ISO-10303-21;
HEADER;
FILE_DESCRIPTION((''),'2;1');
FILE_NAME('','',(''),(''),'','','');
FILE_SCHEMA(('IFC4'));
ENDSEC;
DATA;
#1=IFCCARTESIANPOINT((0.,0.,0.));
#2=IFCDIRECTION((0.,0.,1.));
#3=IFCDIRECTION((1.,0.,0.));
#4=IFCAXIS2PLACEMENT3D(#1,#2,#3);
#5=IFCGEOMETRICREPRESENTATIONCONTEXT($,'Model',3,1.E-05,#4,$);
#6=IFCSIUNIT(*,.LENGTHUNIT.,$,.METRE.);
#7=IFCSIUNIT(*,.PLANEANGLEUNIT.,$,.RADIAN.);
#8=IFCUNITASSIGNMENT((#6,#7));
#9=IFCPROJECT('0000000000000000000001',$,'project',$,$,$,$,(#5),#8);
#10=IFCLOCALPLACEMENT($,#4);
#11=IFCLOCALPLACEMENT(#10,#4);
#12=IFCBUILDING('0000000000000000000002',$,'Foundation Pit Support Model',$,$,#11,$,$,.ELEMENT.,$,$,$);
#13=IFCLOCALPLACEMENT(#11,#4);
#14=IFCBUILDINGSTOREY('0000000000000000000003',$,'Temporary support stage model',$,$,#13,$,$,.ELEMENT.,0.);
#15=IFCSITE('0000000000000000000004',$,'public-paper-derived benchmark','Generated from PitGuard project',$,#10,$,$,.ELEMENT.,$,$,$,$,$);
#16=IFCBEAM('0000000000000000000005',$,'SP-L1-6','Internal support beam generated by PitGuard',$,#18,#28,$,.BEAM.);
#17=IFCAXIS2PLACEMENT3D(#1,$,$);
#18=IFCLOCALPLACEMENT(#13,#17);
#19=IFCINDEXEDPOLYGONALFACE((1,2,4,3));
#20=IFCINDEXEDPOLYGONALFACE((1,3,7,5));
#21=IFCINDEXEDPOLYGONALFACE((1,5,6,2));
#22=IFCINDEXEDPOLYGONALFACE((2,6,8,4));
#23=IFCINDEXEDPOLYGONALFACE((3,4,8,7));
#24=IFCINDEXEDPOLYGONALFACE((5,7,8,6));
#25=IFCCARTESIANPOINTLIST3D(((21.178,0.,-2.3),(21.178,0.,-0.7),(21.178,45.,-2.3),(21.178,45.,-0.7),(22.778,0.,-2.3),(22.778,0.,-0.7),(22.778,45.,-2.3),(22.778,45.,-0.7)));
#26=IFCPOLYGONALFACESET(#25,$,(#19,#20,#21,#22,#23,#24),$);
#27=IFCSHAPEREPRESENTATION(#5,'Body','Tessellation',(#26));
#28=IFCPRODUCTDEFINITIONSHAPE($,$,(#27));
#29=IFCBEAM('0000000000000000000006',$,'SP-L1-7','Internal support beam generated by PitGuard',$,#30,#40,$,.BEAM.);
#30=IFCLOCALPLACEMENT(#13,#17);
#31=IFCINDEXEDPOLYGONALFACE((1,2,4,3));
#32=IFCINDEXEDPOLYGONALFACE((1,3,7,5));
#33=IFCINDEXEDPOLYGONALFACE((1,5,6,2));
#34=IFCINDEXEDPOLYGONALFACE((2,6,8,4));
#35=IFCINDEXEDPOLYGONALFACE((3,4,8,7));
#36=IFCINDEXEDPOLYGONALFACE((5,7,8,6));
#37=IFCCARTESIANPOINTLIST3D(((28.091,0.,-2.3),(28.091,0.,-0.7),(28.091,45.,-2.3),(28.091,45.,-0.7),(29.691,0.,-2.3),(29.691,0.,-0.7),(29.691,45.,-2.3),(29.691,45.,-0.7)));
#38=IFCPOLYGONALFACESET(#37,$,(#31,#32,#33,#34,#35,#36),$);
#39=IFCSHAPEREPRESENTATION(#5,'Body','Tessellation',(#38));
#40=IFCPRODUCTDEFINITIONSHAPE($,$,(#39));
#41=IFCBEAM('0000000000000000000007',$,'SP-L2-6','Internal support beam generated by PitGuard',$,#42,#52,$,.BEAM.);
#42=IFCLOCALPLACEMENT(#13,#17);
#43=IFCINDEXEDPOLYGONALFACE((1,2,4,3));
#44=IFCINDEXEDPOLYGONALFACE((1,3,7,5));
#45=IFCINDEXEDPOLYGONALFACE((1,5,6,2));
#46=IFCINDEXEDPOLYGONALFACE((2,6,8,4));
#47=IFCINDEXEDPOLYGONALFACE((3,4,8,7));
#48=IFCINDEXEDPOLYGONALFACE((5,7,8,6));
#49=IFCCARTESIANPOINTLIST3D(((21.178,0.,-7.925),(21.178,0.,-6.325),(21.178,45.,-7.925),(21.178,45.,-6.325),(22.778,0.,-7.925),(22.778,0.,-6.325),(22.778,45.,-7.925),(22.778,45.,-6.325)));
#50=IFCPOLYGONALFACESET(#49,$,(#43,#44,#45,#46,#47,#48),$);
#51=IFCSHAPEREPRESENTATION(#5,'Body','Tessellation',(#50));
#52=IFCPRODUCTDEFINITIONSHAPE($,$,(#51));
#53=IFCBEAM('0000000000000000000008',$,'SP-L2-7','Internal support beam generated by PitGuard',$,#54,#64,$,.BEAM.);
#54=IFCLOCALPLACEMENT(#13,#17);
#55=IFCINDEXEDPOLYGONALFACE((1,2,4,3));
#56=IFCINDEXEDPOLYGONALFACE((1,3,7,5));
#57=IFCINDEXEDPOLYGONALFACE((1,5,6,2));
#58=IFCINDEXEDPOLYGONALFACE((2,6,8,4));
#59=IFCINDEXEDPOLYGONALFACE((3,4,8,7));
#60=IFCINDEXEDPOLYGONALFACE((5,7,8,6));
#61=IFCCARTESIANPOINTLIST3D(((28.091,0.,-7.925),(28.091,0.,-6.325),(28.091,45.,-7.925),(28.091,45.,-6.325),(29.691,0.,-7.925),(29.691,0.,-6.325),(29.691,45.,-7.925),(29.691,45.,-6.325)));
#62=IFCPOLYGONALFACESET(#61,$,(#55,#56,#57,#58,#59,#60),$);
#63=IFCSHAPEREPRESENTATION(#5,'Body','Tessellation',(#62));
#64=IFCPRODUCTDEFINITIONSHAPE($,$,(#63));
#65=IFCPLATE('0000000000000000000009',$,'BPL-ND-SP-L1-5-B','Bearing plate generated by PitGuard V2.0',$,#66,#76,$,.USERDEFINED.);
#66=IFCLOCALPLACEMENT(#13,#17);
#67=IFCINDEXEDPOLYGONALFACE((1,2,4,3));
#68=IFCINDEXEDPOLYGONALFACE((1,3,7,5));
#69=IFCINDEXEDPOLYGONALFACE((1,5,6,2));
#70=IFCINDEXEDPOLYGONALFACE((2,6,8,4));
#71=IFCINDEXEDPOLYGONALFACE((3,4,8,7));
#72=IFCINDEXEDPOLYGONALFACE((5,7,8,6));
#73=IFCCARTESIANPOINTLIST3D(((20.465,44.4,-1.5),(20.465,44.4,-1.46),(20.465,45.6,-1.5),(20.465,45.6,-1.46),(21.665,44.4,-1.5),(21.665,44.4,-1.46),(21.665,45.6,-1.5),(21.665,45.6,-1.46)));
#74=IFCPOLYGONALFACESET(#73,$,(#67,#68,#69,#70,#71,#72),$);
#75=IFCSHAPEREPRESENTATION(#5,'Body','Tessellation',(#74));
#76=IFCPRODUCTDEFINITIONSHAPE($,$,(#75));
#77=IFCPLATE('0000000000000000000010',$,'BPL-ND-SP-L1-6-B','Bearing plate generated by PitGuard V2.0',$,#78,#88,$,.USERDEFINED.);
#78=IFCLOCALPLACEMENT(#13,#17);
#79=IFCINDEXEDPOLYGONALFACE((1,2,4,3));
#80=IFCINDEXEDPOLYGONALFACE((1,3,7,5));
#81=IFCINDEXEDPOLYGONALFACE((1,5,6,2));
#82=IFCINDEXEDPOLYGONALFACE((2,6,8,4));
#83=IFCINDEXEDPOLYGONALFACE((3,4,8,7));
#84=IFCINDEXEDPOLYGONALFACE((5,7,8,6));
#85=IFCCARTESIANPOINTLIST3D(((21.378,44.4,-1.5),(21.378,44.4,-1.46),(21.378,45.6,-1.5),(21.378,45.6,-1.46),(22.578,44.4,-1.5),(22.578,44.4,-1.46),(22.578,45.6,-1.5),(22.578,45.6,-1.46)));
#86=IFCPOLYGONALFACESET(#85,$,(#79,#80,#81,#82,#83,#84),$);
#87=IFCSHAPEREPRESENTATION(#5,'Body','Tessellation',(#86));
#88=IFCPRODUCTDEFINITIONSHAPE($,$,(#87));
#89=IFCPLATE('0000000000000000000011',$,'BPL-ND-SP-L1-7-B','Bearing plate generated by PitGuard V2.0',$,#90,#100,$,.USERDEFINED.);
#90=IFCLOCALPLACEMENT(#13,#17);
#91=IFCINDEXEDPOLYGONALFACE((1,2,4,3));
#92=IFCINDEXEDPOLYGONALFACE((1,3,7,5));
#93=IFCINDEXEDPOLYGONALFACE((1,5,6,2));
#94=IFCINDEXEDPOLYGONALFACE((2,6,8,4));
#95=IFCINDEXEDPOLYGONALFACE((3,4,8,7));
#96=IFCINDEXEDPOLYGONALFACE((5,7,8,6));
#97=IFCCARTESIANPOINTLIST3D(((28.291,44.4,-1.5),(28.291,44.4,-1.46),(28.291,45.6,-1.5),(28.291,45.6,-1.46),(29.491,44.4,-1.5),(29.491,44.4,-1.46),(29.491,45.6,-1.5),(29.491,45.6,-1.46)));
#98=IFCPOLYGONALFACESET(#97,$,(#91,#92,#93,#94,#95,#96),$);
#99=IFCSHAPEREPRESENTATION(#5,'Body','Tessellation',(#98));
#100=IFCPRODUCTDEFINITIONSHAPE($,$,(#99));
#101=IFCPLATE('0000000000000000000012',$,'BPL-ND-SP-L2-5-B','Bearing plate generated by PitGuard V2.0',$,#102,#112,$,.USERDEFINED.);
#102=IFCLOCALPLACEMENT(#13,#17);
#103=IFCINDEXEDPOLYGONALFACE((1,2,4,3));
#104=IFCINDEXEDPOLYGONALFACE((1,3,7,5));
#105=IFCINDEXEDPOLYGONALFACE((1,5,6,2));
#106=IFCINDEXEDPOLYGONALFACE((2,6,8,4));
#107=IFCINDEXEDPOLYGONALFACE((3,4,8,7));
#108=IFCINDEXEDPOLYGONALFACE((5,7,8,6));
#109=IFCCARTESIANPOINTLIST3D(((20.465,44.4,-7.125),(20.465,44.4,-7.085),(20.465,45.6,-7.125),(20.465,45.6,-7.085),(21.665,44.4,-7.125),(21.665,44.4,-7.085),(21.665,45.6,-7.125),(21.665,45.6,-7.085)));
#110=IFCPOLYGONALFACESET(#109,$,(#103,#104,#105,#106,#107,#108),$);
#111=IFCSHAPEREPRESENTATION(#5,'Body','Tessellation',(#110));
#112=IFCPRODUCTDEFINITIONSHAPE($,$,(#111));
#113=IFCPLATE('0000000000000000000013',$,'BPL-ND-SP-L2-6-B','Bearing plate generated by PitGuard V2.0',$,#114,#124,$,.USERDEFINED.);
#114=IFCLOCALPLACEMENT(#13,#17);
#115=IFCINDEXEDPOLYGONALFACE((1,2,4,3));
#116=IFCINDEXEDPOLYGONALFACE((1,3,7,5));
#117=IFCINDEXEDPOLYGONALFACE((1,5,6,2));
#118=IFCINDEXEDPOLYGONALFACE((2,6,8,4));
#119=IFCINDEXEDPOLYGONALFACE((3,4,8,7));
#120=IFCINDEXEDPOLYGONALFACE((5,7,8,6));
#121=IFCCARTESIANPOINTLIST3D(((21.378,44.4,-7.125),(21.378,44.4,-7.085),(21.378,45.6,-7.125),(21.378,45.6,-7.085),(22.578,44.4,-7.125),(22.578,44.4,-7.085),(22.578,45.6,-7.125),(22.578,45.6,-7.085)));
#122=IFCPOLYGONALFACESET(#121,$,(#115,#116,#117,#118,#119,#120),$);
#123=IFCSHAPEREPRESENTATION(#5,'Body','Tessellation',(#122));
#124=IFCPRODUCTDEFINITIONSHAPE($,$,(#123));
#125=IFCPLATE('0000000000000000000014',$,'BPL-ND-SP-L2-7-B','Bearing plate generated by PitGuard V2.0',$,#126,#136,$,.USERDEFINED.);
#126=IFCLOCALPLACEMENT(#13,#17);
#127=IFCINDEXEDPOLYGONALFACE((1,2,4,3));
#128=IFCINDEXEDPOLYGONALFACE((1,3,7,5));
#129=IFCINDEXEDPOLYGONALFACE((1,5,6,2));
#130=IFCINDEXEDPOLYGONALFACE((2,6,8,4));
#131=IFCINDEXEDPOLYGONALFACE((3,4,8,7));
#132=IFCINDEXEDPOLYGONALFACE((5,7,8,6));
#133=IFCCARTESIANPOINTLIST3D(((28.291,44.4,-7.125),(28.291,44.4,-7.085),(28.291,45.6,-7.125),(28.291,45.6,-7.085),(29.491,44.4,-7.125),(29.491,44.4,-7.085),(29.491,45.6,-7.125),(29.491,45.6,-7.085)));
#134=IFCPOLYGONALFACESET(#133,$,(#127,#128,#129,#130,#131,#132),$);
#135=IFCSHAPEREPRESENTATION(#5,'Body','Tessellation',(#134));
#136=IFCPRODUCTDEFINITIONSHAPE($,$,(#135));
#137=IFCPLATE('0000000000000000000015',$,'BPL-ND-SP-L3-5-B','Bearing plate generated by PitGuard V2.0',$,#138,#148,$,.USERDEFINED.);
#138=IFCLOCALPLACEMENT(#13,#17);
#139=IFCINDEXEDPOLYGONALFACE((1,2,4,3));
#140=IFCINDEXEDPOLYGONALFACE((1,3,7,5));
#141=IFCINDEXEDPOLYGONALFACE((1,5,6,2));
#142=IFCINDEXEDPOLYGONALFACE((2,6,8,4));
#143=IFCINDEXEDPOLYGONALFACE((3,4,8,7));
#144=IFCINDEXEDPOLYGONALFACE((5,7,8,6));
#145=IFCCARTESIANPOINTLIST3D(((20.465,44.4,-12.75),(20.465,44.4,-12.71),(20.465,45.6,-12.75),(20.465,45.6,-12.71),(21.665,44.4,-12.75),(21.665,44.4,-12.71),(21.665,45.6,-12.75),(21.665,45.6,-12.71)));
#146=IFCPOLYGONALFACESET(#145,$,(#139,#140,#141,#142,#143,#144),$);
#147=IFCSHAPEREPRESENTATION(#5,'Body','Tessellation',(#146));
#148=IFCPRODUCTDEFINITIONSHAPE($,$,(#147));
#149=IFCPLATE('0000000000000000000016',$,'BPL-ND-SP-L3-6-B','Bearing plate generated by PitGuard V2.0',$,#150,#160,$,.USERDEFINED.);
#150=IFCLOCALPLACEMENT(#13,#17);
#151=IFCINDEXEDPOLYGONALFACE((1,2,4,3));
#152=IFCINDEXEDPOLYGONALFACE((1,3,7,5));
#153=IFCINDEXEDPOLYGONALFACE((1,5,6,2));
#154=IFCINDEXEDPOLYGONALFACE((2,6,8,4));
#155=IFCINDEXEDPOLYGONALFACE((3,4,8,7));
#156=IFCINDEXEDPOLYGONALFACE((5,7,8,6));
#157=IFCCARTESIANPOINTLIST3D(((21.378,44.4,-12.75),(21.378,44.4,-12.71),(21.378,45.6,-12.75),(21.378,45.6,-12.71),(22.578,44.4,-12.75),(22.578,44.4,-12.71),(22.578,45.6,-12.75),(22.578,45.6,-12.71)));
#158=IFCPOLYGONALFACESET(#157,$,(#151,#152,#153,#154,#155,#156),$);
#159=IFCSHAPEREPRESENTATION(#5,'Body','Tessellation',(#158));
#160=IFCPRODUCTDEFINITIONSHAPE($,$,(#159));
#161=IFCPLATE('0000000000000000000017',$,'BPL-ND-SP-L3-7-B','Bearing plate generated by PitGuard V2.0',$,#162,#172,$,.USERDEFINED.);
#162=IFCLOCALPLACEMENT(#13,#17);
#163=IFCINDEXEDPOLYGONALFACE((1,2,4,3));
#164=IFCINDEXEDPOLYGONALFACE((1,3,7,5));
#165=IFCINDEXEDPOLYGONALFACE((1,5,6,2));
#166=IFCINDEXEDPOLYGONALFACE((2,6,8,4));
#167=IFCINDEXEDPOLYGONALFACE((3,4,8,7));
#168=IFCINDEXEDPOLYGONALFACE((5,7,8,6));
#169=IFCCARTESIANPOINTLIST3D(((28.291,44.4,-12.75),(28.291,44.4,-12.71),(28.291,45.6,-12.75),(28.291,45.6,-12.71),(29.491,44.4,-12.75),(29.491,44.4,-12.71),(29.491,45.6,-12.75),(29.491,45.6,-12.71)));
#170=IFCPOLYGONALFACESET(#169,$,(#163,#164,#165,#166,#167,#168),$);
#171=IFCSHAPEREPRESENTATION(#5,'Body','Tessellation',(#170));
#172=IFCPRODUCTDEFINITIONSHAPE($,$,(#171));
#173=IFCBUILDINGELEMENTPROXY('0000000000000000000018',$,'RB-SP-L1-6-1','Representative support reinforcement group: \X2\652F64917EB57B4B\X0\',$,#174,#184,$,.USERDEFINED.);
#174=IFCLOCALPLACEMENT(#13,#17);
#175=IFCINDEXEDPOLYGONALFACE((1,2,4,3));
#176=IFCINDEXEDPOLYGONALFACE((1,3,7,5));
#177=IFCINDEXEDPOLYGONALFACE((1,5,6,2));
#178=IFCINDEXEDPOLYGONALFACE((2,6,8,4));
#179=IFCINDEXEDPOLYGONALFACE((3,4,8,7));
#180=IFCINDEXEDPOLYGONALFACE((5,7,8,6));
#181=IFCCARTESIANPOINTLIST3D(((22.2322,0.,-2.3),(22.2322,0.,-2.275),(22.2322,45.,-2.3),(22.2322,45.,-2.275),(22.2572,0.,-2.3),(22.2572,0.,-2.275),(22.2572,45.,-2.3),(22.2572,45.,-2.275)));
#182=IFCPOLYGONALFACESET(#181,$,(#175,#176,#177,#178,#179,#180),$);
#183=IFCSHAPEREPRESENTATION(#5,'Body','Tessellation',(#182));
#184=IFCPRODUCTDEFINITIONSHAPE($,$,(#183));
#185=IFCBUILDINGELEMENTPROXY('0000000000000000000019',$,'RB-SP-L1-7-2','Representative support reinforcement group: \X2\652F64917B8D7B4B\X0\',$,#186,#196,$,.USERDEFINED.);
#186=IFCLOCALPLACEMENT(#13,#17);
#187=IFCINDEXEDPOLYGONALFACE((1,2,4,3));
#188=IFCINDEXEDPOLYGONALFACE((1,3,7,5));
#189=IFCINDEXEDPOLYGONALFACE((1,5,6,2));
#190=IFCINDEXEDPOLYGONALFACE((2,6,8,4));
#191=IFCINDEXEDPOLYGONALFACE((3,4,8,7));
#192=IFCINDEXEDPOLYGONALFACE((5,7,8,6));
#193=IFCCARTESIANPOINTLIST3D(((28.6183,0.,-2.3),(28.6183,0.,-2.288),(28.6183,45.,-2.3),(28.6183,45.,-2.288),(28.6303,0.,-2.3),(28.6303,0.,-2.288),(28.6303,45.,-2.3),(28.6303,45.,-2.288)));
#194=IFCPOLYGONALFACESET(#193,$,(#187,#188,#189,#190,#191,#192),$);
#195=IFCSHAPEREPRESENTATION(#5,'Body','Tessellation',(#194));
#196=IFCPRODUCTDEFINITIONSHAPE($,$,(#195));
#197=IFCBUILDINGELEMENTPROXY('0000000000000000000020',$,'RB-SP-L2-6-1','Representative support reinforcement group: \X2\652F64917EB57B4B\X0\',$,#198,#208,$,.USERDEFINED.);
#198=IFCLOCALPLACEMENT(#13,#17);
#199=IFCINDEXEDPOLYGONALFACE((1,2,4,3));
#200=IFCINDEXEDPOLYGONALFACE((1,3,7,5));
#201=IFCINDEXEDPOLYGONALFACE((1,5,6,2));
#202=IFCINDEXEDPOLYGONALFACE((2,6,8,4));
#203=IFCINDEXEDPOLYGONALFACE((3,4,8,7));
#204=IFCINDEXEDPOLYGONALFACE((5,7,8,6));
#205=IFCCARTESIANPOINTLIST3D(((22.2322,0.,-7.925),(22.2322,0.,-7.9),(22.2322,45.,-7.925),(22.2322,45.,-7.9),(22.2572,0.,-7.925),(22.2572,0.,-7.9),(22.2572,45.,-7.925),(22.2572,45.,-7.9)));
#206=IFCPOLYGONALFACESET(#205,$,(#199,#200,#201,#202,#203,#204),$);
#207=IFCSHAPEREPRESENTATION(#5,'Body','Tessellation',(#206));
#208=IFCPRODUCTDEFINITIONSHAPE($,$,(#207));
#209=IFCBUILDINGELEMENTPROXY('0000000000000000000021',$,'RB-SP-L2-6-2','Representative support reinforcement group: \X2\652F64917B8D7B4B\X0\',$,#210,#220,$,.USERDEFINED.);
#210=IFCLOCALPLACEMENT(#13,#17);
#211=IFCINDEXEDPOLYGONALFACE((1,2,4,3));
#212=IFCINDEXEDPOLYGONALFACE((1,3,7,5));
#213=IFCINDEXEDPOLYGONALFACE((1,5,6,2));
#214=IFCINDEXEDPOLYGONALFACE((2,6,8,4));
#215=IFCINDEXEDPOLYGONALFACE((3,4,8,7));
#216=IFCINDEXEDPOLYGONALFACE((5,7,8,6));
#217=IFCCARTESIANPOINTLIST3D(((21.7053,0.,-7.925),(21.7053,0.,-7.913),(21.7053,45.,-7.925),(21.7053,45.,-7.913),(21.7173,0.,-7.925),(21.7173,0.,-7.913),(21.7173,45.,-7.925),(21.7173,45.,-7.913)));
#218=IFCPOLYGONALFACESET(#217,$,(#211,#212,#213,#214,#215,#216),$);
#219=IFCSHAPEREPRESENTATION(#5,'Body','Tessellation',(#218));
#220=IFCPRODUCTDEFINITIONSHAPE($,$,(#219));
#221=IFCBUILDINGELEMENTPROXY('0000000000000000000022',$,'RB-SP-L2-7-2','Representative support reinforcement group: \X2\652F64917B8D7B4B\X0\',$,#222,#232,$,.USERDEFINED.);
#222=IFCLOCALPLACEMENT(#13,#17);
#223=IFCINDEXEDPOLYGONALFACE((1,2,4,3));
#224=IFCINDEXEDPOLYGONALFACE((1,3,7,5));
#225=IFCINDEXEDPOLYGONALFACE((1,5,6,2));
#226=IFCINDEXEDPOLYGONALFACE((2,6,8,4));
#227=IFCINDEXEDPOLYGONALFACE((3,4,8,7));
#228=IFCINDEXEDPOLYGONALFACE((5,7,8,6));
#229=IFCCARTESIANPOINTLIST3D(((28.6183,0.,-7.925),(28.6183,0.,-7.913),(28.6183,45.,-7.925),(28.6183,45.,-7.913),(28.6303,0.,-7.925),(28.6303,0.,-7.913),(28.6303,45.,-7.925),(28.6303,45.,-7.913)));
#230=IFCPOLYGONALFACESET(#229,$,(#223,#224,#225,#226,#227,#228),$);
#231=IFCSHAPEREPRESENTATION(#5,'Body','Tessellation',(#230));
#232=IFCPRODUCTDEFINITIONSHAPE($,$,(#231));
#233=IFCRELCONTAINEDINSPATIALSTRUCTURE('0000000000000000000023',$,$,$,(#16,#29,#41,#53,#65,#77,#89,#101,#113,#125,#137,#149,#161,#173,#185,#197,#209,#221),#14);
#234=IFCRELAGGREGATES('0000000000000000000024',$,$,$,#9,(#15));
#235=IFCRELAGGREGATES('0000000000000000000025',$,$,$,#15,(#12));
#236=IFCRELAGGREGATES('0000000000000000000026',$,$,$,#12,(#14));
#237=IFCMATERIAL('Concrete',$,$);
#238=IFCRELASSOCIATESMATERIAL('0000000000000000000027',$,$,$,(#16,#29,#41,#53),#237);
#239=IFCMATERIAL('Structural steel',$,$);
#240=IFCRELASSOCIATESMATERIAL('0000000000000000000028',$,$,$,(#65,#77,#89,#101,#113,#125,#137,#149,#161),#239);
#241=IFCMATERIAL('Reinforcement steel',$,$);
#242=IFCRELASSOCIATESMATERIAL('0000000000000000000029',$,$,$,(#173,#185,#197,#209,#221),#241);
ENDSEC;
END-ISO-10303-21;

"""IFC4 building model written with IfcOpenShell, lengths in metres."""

from ifc_helpers import new_model, si_unit, frame, origin_with_axes, origin_2d, place, context, project, spatial, rectangle, extrude, material, element, save


model = new_model("IFC4")

# Units and contexts
model_context = context("Model", 3, precision=1e-05, world=origin_with_axes())
ifc_project = project(units=[si_unit("LENGTHUNIT", "METRE"), si_unit("PLANEANGLEUNIT", "RADIAN")], contexts=[model_context])

# Site, building, storey
site_placement = place(None, origin_with_axes())
site = spatial("IfcSite", under=ifc_project, at=site_placement, Name="public-paper-derived benchmark", Description="Generated from PitGuard project", CompositionType="ELEMENT")
building_placement = place(site_placement, origin_with_axes())
building = spatial("IfcBuilding", under=site, at=building_placement, Name="Foundation Pit Support Model", CompositionType="ELEMENT")
storey_placement = place(building_placement, origin_with_axes())
storey = spatial("IfcBuildingStorey", under=building, at=storey_placement, Name="Temporary support stage model", CompositionType="ELEMENT", Elevation=0.0)

# Beams
ifc_material_1 = material(Name="Concrete")
for number, where, z_axis, x_axis, name in (
    (1, (21.978, 22.5, -2.3), (0.0, 0.0, 1.0), (0.0, 1.0, 0.0), "SP-L1-6"),
    (2, (28.891, 22.5, -2.3), (0.0, 0.0, 1.0), (0.0, 1.0, 0.0), "SP-L1-7"),
    (3, (21.978, 22.5, -7.925), (0.0, 0.0, 1.0), (0.0, 1.0, 0.0), "SP-L2-6"),
    (4, (28.891, 22.5, -7.925), (0.0, 0.0, 1.0), (0.0, 1.0, 0.0), "SP-L2-7"),
):
    element("IfcBeam", number, at=place(storey_placement, frame(where, z_axis=z_axis, x_axis=x_axis)), inside=storey, material=ifc_material_1, Name=name, Description="Internal support beam generated by PitGuard", PredefinedType="BEAM", context=model_context, shape_type="SweptSolid", body=[
        extrude(rectangle(XDim=45.0, YDim=1.6, at=origin_2d()), origin_with_axes(), (0.0, 0.0, 1.0), 1.6),
    ])

# Plates
ifc_material_2 = material(Name="Structural steel")
for number, where, z_axis, x_axis, name in (
    (5, (21.065, 45.0, -1.5), (0.0, 0.0, 1.0), (1.0, 0.0, 0.0), "BPL-ND-SP-L1-5-B"),
    (6, (21.978, 45.0, -1.5), (0.0, 0.0, 1.0), (1.0, 0.0, 0.0), "BPL-ND-SP-L1-6-B"),
    (7, (28.891, 45.0, -1.5), (0.0, 0.0, 1.0), (1.0, 0.0, 0.0), "BPL-ND-SP-L1-7-B"),
    (8, (21.065, 45.0, -7.125), (0.0, 0.0, 1.0), (1.0, 0.0, 0.0), "BPL-ND-SP-L2-5-B"),
    (9, (21.978, 45.0, -7.125), (0.0, 0.0, 1.0), (1.0, 0.0, 0.0), "BPL-ND-SP-L2-6-B"),
    (10, (28.891, 45.0, -7.125), (0.0, 0.0, 1.0), (1.0, 0.0, 0.0), "BPL-ND-SP-L2-7-B"),
    (11, (21.065, 45.0, -12.75), (0.0, 0.0, 1.0), (1.0, 0.0, 0.0), "BPL-ND-SP-L3-5-B"),
    (12, (21.978, 45.0, -12.75), (0.0, 0.0, 1.0), (1.0, 0.0, 0.0), "BPL-ND-SP-L3-6-B"),
    (13, (28.891, 45.0, -12.75), (0.0, 0.0, 1.0), (1.0, 0.0, 0.0), "BPL-ND-SP-L3-7-B"),
):
    element("IfcPlate", number, at=place(storey_placement, frame(where, z_axis=z_axis, x_axis=x_axis)), inside=storey, material=ifc_material_2, Name=name, Description="Bearing plate generated by PitGuard V2.0", PredefinedType="USERDEFINED", context=model_context, shape_type="SweptSolid", body=[
        extrude(rectangle(XDim=1.2, YDim=1.2, at=origin_2d()), origin_with_axes(), (0.0, 0.0, 1.0), 0.04),
    ])

# Building element proxies
ifc_material_3 = material(Name="Reinforcement steel")
proxy_1_placement = place(storey_placement, frame((22.2447, 22.5, -2.3), z_axis=(0.0, 0.0, 1.0), x_axis=(0.0, 1.0, 0.0)))
element("IfcBuildingElementProxy", 14, at=proxy_1_placement, inside=storey, material=ifc_material_3, Name="RB-SP-L1-6-1", Description="Representative support reinforcement group: 支撑纵筋", PredefinedType="USERDEFINED", context=model_context, shape_type="SweptSolid", body=[
    extrude(rectangle(XDim=45.0, YDim=0.025, at=origin_2d()), origin_with_axes(), (0.0, 0.0, 1.0), 0.025),
])
proxy_2_placement = place(storey_placement, frame((28.6243, 22.5, -2.3), z_axis=(0.0, 0.0, 1.0), x_axis=(0.0, 1.0, 0.0)))
element("IfcBuildingElementProxy", 15, at=proxy_2_placement, inside=storey, material=ifc_material_3, Name="RB-SP-L1-7-2", Description="Representative support reinforcement group: 支撑箍筋", PredefinedType="USERDEFINED", context=model_context, shape_type="SweptSolid", body=[
    extrude(rectangle(XDim=45.0, YDim=0.012, at=origin_2d()), origin_with_axes(), (0.0, 0.0, 1.0), 0.012),
])
proxy_3_placement = place(storey_placement, frame((22.2447, 22.5, -7.925), z_axis=(0.0, 0.0, 1.0), x_axis=(0.0, 1.0, 0.0)))
element("IfcBuildingElementProxy", 16, at=proxy_3_placement, inside=storey, material=ifc_material_3, Name="RB-SP-L2-6-1", Description="Representative support reinforcement group: 支撑纵筋", PredefinedType="USERDEFINED", context=model_context, shape_type="SweptSolid", body=[
    extrude(rectangle(XDim=45.0, YDim=0.025, at=origin_2d()), origin_with_axes(), (0.0, 0.0, 1.0), 0.025),
])
for number, where, z_axis, x_axis, name in (
    (17, (21.7113, 22.5, -7.925), (0.0, 0.0, 1.0), (0.0, 1.0, 0.0), "RB-SP-L2-6-2"),
    (18, (28.6243, 22.5, -7.925), (0.0, 0.0, 1.0), (0.0, 1.0, 0.0), "RB-SP-L2-7-2"),
):
    element("IfcBuildingElementProxy", number, at=place(storey_placement, frame(where, z_axis=z_axis, x_axis=x_axis)), inside=storey, material=ifc_material_3, Name=name, Description="Representative support reinforcement group: 支撑箍筋", PredefinedType="USERDEFINED", context=model_context, shape_type="SweptSolid", body=[
        extrude(rectangle(XDim=45.0, YDim=0.012, at=origin_2d()), origin_with_axes(), (0.0, 0.0, 1.0), 0.012),
    ])

save(model, "model.ifc")
